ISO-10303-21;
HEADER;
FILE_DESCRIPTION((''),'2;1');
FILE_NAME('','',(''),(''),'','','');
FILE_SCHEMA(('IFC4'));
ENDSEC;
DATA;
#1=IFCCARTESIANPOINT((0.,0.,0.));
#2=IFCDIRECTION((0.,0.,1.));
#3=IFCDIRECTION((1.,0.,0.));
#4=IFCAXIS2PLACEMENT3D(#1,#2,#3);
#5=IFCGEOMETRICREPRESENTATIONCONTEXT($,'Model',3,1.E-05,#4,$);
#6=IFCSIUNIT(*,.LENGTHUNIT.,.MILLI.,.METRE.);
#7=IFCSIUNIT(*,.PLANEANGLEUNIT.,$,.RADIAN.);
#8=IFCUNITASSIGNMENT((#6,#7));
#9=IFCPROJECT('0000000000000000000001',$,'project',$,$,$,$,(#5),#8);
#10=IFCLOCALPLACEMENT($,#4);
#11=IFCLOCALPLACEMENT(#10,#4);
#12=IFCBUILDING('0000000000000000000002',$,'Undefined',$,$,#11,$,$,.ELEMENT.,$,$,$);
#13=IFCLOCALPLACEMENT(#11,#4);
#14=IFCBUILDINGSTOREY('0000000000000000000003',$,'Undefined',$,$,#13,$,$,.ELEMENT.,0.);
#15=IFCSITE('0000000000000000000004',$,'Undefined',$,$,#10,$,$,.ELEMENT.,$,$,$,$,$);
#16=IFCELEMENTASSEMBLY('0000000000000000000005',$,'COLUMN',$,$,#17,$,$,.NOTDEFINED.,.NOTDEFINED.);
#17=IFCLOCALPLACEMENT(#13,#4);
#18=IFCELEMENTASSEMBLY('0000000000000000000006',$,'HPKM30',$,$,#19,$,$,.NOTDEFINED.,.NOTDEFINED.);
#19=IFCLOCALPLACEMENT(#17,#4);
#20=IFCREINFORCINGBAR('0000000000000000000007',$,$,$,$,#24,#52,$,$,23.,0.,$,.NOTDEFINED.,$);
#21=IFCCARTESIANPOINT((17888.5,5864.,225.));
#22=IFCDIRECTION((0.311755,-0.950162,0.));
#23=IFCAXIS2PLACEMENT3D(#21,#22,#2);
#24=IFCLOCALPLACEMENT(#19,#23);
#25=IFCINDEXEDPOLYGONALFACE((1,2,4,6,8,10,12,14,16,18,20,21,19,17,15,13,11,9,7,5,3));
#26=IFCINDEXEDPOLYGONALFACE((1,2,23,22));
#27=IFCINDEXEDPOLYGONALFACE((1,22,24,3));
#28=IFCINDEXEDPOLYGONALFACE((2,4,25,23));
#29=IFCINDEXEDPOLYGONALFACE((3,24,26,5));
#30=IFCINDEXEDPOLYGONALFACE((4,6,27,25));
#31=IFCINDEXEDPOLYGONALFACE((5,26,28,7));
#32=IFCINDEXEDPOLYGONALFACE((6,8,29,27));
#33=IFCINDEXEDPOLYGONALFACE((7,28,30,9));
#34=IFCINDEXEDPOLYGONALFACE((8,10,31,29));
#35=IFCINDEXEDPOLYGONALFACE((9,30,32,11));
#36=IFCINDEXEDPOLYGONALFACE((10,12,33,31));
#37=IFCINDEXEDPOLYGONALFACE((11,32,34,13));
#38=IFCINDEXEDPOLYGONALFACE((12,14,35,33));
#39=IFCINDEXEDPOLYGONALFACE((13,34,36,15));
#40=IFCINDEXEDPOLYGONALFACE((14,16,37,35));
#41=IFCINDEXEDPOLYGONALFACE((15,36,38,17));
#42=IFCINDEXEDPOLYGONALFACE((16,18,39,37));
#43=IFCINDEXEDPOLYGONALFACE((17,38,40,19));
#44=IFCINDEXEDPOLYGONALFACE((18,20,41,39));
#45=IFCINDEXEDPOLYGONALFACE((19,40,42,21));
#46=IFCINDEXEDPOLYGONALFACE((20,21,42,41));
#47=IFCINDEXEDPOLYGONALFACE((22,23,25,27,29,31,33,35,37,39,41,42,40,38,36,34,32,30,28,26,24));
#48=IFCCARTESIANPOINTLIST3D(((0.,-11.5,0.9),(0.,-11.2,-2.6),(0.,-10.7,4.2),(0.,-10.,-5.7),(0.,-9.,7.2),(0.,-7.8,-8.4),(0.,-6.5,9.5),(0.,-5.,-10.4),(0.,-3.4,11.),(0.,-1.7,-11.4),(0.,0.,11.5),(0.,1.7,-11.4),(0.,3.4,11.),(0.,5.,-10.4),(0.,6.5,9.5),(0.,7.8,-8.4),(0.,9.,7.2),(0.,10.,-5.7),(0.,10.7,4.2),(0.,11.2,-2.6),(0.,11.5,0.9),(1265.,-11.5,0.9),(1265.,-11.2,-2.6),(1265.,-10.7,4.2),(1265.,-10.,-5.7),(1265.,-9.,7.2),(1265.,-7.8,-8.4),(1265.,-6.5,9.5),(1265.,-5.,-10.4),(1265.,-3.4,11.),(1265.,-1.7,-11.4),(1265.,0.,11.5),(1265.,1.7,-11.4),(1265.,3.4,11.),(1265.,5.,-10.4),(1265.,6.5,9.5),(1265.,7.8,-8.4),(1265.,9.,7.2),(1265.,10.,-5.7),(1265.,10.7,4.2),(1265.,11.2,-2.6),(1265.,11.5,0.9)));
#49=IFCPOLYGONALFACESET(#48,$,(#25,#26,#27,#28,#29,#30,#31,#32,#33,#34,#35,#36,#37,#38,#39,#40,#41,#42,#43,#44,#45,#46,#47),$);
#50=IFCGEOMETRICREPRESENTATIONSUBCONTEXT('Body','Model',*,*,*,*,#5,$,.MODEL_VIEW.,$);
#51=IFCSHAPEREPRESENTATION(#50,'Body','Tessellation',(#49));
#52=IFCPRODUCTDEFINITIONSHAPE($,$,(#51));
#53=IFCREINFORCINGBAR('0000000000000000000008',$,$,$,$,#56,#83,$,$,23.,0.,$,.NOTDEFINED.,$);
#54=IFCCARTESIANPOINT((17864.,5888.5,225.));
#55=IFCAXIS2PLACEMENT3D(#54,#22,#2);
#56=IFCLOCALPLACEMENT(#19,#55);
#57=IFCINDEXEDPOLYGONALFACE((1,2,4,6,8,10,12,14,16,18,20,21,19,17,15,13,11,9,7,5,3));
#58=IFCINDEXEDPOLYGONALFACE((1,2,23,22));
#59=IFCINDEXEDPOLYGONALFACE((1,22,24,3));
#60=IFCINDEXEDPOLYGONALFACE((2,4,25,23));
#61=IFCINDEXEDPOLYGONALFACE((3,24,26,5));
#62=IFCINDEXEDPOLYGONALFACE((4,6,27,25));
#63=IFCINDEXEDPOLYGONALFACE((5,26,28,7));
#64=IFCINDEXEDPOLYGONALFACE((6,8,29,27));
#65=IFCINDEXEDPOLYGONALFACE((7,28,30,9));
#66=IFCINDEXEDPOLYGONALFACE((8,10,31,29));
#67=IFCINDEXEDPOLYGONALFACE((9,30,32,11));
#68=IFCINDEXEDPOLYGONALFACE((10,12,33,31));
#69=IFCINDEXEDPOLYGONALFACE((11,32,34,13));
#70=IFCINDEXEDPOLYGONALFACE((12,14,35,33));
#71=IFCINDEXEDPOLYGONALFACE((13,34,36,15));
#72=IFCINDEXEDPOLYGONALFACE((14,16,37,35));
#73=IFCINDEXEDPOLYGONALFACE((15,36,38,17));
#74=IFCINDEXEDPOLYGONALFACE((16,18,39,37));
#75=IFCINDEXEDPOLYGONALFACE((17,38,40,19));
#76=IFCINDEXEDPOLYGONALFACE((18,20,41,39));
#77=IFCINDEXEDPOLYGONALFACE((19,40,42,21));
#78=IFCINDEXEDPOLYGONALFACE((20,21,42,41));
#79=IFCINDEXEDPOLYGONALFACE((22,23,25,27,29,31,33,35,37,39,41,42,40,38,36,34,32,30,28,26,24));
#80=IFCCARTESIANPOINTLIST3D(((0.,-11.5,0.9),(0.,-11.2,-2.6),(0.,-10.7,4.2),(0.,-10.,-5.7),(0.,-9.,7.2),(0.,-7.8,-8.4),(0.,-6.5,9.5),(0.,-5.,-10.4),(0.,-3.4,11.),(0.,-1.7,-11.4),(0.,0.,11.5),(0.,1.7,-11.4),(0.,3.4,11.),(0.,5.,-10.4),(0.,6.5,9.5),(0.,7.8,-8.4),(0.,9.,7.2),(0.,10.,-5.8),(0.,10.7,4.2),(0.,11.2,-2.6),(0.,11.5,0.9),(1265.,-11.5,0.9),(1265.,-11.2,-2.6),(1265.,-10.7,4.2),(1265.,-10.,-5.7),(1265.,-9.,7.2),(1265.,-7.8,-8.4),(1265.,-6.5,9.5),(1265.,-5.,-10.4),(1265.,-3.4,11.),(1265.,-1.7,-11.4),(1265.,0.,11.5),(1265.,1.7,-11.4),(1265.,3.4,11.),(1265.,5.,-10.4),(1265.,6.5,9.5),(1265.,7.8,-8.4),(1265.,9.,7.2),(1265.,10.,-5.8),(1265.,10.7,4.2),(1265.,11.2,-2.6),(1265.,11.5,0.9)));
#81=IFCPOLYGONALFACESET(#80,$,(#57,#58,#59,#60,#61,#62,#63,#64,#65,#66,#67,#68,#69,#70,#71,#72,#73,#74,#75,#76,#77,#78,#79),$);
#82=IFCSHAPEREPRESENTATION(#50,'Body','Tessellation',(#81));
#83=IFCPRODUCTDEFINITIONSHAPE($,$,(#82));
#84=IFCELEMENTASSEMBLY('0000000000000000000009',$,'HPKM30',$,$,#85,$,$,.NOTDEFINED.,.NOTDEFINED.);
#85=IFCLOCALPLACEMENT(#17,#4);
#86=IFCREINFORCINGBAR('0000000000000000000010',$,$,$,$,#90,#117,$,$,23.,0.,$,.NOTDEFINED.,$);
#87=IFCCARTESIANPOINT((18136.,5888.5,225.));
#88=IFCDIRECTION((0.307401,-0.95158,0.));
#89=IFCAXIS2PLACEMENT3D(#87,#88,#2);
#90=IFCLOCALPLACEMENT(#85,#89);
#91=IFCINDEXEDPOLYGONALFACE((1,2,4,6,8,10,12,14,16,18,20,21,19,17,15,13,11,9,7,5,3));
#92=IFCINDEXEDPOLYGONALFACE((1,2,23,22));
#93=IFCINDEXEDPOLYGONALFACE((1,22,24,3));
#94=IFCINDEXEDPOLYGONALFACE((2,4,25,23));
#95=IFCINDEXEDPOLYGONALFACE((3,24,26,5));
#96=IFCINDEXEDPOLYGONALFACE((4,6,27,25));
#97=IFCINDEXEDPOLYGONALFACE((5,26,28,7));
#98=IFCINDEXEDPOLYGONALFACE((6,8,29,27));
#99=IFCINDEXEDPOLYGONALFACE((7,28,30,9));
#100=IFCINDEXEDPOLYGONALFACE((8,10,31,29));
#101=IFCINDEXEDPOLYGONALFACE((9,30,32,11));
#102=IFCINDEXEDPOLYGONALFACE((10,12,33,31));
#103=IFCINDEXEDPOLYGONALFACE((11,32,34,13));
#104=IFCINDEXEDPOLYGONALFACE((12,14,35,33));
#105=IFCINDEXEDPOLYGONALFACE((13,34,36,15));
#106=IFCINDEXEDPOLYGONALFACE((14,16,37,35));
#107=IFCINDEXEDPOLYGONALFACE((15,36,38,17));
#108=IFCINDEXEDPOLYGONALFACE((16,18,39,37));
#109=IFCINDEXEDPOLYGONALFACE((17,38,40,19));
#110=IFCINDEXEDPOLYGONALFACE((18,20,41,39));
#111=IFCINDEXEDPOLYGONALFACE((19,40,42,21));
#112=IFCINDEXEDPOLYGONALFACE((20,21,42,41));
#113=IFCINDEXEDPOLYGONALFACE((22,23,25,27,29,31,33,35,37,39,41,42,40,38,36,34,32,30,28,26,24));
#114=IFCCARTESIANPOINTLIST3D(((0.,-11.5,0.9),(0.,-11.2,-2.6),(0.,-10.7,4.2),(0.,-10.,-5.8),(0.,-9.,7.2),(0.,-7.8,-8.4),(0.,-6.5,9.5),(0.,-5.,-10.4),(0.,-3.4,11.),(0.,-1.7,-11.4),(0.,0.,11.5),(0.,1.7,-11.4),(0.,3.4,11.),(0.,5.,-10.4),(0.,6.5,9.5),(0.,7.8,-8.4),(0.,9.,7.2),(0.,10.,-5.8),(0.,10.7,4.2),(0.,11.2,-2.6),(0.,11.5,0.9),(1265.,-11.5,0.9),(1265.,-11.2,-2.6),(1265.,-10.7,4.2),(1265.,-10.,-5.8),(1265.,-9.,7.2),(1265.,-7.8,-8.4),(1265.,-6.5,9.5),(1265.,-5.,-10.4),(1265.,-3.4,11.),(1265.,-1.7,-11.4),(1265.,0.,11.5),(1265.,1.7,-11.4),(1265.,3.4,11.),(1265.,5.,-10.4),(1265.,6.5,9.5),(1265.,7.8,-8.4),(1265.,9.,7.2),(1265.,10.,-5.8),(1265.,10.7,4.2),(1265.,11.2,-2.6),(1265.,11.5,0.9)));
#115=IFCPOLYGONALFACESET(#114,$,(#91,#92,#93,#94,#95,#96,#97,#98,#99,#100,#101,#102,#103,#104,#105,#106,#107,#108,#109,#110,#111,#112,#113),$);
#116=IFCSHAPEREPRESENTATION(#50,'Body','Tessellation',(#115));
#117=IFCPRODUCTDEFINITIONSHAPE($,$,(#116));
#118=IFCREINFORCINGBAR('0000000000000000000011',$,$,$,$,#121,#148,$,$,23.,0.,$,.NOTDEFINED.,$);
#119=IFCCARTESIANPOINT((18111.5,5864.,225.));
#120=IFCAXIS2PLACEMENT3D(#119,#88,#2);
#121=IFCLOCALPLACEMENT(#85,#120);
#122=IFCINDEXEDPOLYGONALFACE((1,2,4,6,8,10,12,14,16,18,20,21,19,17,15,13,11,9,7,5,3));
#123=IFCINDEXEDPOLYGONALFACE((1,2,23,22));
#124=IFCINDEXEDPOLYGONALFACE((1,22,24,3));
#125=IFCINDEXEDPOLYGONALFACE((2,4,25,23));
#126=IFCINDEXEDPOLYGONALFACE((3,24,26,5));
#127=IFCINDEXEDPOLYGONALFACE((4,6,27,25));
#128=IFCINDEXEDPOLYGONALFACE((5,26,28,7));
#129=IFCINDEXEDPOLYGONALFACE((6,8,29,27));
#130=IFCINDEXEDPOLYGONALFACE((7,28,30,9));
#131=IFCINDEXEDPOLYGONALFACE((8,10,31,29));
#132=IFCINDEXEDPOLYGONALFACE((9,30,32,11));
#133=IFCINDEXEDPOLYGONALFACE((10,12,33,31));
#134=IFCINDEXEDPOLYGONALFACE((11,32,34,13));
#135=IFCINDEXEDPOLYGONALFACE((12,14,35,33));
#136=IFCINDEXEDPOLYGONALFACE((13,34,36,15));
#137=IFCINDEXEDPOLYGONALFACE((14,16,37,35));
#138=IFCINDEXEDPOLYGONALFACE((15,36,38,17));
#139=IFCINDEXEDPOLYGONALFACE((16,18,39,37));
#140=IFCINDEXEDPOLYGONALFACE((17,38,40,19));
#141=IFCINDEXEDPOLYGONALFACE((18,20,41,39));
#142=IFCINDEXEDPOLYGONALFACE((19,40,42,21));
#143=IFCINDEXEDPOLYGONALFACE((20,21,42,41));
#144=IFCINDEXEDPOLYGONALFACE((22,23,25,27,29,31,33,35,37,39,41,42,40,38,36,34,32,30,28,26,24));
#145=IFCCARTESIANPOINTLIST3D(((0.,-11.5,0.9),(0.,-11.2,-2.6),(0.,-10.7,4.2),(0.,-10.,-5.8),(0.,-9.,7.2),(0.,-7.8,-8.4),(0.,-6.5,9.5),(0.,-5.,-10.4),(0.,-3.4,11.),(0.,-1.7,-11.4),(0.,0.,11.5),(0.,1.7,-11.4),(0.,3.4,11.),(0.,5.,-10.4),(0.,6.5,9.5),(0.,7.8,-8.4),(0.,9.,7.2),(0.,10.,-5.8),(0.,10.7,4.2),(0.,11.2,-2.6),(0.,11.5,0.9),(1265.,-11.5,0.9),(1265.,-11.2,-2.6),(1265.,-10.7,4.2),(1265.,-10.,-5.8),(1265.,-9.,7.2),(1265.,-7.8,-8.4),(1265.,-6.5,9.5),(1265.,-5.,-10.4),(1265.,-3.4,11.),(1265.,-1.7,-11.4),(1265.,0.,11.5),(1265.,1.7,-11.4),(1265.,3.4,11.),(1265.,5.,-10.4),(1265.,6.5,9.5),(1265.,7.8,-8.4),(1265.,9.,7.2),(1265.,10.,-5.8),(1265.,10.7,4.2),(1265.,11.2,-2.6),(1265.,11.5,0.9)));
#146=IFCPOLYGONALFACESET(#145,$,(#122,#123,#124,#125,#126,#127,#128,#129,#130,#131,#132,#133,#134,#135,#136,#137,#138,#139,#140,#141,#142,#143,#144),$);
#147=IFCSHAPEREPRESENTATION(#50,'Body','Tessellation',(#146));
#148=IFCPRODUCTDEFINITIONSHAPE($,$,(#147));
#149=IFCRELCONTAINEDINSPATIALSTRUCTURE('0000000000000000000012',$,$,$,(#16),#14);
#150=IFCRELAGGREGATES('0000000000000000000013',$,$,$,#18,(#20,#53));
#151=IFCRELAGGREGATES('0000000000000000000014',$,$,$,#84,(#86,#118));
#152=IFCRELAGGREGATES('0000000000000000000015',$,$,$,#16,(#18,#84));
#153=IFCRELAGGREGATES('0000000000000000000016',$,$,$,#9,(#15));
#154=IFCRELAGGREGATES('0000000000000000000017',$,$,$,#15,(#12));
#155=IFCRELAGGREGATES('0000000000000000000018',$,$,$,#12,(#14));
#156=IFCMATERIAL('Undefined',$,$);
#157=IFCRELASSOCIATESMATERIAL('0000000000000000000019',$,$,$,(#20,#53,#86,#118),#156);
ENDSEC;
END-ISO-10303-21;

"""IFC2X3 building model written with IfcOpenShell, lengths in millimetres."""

from ifc_helpers import new_model, entity, si_unit, frame, origin_with_axes, place, context, subcontext, project, spatial, source, transform, mapped, material, element, aggregate, save


model = new_model("IFC2X3")

# Units and contexts
model_context = context("Model", 3, precision=1e-05, world=origin_with_axes())
body_context = subcontext(model_context, "Body", "Model", "MODEL_VIEW")
ifc_project = project(units=[si_unit("LENGTHUNIT", "METRE", prefix="MILLI"), si_unit("PLANEANGLEUNIT", "RADIAN")], contexts=[model_context])

# Site, building, storey
site_placement = place(None, origin_with_axes())
site = spatial("IfcSite", under=ifc_project, at=site_placement, Name="Undefined", CompositionType="ELEMENT")
building_placement = place(site_placement, origin_with_axes())
building = spatial("IfcBuilding", under=site, at=building_placement, Name="Undefined", CompositionType="ELEMENT")
storey_placement = place(building_placement, origin_with_axes())
storey = spatial("IfcBuildingStorey", under=building, at=storey_placement, Name="Undefined", CompositionType="ELEMENT", Elevation=0.0)

# Element assembly
assembly_1_placement = place(storey_placement, origin_with_axes())
assembly_1 = element("IfcElementAssembly", 1, at=assembly_1_placement, inside=storey, Name="COLUMN", AssemblyPlace="NOTDEFINED", PredefinedType="NOTDEFINED")

# Shared definitions
ifc_material_1 = material(Name="Undefined")

# Element assemblies, reinforcing bars
assembly_2_placement = place(assembly_1_placement, origin_with_axes())
assembly_2 = element("IfcElementAssembly", 2, at=assembly_2_placement, Name="HPKM30", AssemblyPlace="NOTDEFINED", PredefinedType="NOTDEFINED")
shared_shape_1 = source(origin_with_axes(), body_context, "Body", "AdvancedSweptSolid", [
    entity("IfcSweptDiskSolid", entity("IfcTrimmedCurve", entity("IfcLine", entity("IfcCartesianPoint", [0.0, 0.0, 0.0]), entity("IfcVector", entity("IfcDirection", [1.0, 0.0, 0.0]), 1.0)), [entity("IfcParameterValue", 0.0)], [entity("IfcParameterValue", 1265.0)], True, "PARAMETER"), 11.5, None, 0.0, 1265.0),
])
reinforcing_bar_1_placement = place(assembly_2_placement, frame((17888.5, 5864.0, 225.0), z_axis=(0.311755, -0.950162, 0.0), x_axis=(0.0, 0.0, 1.0)))
reinforcing_bar_1 = element("IfcReinforcingBar", 3, at=reinforcing_bar_1_placement, material=ifc_material_1, BarRole="NOTDEFINED", CrossSectionArea=0.0, NominalDiameter=23.0, context=body_context, shape_type="MappedRepresentation", body=[
    mapped(shared_shape_1, transform((0.0, 0.0, 0.0))),
])
shared_shape_2 = source(origin_with_axes(), body_context, "Body", "AdvancedSweptSolid", [
    entity("IfcSweptDiskSolid", entity("IfcTrimmedCurve", entity("IfcLine", entity("IfcCartesianPoint", [0.0, 0.0, 0.0]), entity("IfcVector", entity("IfcDirection", [1.0, 0.0, 0.0]), 1.0)), [entity("IfcParameterValue", 0.0)], [entity("IfcParameterValue", 1265.0)], True, "PARAMETER"), 11.5, None, 0.0, 1265.0),
])
reinforcing_bar_2_placement = place(assembly_2_placement, frame((17864.0, 5888.5, 225.0), z_axis=(0.311755, -0.950162, 0.0), x_axis=(0.0, 0.0, 1.0)))
reinforcing_bar_2 = element("IfcReinforcingBar", 4, at=reinforcing_bar_2_placement, material=ifc_material_1, BarRole="NOTDEFINED", CrossSectionArea=0.0, NominalDiameter=23.0, context=body_context, shape_type="MappedRepresentation", body=[
    mapped(shared_shape_2, transform((0.0, 0.0, 0.0))),
])
aggregate(assembly_2, [reinforcing_bar_1, reinforcing_bar_2])
assembly_3_placement = place(assembly_1_placement, origin_with_axes())
assembly_3 = element("IfcElementAssembly", 5, at=assembly_3_placement, Name="HPKM30", AssemblyPlace="NOTDEFINED", PredefinedType="NOTDEFINED")
shared_shape_3 = source(origin_with_axes(), body_context, "Body", "AdvancedSweptSolid", [
    entity("IfcSweptDiskSolid", entity("IfcTrimmedCurve", entity("IfcLine", entity("IfcCartesianPoint", [0.0, 0.0, 0.0]), entity("IfcVector", entity("IfcDirection", [1.0, 0.0, 0.0]), 1.0)), [entity("IfcParameterValue", 0.0)], [entity("IfcParameterValue", 1265.0)], True, "PARAMETER"), 11.5, None, 0.0, 1265.0),
])
reinforcing_bar_3_placement = place(assembly_3_placement, frame((18136.0, 5888.5, 225.0), z_axis=(0.307401, -0.95158, 0.0), x_axis=(0.0, 0.0, 1.0)))
reinforcing_bar_3 = element("IfcReinforcingBar", 6, at=reinforcing_bar_3_placement, material=ifc_material_1, BarRole="NOTDEFINED", CrossSectionArea=0.0, NominalDiameter=23.0, context=body_context, shape_type="MappedRepresentation", body=[
    mapped(shared_shape_3, transform((0.0, 0.0, 0.0))),
])
shared_shape_4 = source(origin_with_axes(), body_context, "Body", "AdvancedSweptSolid", [
    entity("IfcSweptDiskSolid", entity("IfcTrimmedCurve", entity("IfcLine", entity("IfcCartesianPoint", [0.0, 0.0, 0.0]), entity("IfcVector", entity("IfcDirection", [1.0, 0.0, 0.0]), 1.0)), [entity("IfcParameterValue", 0.0)], [entity("IfcParameterValue", 1265.0)], True, "PARAMETER"), 11.5, None, 0.0, 1265.0),
])
reinforcing_bar_4_placement = place(assembly_3_placement, frame((18111.5, 5864.0, 225.0), z_axis=(0.307401, -0.95158, 0.0), x_axis=(0.0, 0.0, 1.0)))
reinforcing_bar_4 = element("IfcReinforcingBar", 7, at=reinforcing_bar_4_placement, material=ifc_material_1, BarRole="NOTDEFINED", CrossSectionArea=0.0, NominalDiameter=23.0, context=body_context, shape_type="MappedRepresentation", body=[
    mapped(shared_shape_4, transform((0.0, 0.0, 0.0))),
])
aggregate(assembly_3, [reinforcing_bar_3, reinforcing_bar_4])

aggregate(assembly_1, [assembly_2, assembly_3])

save(model, "model.ifc")
